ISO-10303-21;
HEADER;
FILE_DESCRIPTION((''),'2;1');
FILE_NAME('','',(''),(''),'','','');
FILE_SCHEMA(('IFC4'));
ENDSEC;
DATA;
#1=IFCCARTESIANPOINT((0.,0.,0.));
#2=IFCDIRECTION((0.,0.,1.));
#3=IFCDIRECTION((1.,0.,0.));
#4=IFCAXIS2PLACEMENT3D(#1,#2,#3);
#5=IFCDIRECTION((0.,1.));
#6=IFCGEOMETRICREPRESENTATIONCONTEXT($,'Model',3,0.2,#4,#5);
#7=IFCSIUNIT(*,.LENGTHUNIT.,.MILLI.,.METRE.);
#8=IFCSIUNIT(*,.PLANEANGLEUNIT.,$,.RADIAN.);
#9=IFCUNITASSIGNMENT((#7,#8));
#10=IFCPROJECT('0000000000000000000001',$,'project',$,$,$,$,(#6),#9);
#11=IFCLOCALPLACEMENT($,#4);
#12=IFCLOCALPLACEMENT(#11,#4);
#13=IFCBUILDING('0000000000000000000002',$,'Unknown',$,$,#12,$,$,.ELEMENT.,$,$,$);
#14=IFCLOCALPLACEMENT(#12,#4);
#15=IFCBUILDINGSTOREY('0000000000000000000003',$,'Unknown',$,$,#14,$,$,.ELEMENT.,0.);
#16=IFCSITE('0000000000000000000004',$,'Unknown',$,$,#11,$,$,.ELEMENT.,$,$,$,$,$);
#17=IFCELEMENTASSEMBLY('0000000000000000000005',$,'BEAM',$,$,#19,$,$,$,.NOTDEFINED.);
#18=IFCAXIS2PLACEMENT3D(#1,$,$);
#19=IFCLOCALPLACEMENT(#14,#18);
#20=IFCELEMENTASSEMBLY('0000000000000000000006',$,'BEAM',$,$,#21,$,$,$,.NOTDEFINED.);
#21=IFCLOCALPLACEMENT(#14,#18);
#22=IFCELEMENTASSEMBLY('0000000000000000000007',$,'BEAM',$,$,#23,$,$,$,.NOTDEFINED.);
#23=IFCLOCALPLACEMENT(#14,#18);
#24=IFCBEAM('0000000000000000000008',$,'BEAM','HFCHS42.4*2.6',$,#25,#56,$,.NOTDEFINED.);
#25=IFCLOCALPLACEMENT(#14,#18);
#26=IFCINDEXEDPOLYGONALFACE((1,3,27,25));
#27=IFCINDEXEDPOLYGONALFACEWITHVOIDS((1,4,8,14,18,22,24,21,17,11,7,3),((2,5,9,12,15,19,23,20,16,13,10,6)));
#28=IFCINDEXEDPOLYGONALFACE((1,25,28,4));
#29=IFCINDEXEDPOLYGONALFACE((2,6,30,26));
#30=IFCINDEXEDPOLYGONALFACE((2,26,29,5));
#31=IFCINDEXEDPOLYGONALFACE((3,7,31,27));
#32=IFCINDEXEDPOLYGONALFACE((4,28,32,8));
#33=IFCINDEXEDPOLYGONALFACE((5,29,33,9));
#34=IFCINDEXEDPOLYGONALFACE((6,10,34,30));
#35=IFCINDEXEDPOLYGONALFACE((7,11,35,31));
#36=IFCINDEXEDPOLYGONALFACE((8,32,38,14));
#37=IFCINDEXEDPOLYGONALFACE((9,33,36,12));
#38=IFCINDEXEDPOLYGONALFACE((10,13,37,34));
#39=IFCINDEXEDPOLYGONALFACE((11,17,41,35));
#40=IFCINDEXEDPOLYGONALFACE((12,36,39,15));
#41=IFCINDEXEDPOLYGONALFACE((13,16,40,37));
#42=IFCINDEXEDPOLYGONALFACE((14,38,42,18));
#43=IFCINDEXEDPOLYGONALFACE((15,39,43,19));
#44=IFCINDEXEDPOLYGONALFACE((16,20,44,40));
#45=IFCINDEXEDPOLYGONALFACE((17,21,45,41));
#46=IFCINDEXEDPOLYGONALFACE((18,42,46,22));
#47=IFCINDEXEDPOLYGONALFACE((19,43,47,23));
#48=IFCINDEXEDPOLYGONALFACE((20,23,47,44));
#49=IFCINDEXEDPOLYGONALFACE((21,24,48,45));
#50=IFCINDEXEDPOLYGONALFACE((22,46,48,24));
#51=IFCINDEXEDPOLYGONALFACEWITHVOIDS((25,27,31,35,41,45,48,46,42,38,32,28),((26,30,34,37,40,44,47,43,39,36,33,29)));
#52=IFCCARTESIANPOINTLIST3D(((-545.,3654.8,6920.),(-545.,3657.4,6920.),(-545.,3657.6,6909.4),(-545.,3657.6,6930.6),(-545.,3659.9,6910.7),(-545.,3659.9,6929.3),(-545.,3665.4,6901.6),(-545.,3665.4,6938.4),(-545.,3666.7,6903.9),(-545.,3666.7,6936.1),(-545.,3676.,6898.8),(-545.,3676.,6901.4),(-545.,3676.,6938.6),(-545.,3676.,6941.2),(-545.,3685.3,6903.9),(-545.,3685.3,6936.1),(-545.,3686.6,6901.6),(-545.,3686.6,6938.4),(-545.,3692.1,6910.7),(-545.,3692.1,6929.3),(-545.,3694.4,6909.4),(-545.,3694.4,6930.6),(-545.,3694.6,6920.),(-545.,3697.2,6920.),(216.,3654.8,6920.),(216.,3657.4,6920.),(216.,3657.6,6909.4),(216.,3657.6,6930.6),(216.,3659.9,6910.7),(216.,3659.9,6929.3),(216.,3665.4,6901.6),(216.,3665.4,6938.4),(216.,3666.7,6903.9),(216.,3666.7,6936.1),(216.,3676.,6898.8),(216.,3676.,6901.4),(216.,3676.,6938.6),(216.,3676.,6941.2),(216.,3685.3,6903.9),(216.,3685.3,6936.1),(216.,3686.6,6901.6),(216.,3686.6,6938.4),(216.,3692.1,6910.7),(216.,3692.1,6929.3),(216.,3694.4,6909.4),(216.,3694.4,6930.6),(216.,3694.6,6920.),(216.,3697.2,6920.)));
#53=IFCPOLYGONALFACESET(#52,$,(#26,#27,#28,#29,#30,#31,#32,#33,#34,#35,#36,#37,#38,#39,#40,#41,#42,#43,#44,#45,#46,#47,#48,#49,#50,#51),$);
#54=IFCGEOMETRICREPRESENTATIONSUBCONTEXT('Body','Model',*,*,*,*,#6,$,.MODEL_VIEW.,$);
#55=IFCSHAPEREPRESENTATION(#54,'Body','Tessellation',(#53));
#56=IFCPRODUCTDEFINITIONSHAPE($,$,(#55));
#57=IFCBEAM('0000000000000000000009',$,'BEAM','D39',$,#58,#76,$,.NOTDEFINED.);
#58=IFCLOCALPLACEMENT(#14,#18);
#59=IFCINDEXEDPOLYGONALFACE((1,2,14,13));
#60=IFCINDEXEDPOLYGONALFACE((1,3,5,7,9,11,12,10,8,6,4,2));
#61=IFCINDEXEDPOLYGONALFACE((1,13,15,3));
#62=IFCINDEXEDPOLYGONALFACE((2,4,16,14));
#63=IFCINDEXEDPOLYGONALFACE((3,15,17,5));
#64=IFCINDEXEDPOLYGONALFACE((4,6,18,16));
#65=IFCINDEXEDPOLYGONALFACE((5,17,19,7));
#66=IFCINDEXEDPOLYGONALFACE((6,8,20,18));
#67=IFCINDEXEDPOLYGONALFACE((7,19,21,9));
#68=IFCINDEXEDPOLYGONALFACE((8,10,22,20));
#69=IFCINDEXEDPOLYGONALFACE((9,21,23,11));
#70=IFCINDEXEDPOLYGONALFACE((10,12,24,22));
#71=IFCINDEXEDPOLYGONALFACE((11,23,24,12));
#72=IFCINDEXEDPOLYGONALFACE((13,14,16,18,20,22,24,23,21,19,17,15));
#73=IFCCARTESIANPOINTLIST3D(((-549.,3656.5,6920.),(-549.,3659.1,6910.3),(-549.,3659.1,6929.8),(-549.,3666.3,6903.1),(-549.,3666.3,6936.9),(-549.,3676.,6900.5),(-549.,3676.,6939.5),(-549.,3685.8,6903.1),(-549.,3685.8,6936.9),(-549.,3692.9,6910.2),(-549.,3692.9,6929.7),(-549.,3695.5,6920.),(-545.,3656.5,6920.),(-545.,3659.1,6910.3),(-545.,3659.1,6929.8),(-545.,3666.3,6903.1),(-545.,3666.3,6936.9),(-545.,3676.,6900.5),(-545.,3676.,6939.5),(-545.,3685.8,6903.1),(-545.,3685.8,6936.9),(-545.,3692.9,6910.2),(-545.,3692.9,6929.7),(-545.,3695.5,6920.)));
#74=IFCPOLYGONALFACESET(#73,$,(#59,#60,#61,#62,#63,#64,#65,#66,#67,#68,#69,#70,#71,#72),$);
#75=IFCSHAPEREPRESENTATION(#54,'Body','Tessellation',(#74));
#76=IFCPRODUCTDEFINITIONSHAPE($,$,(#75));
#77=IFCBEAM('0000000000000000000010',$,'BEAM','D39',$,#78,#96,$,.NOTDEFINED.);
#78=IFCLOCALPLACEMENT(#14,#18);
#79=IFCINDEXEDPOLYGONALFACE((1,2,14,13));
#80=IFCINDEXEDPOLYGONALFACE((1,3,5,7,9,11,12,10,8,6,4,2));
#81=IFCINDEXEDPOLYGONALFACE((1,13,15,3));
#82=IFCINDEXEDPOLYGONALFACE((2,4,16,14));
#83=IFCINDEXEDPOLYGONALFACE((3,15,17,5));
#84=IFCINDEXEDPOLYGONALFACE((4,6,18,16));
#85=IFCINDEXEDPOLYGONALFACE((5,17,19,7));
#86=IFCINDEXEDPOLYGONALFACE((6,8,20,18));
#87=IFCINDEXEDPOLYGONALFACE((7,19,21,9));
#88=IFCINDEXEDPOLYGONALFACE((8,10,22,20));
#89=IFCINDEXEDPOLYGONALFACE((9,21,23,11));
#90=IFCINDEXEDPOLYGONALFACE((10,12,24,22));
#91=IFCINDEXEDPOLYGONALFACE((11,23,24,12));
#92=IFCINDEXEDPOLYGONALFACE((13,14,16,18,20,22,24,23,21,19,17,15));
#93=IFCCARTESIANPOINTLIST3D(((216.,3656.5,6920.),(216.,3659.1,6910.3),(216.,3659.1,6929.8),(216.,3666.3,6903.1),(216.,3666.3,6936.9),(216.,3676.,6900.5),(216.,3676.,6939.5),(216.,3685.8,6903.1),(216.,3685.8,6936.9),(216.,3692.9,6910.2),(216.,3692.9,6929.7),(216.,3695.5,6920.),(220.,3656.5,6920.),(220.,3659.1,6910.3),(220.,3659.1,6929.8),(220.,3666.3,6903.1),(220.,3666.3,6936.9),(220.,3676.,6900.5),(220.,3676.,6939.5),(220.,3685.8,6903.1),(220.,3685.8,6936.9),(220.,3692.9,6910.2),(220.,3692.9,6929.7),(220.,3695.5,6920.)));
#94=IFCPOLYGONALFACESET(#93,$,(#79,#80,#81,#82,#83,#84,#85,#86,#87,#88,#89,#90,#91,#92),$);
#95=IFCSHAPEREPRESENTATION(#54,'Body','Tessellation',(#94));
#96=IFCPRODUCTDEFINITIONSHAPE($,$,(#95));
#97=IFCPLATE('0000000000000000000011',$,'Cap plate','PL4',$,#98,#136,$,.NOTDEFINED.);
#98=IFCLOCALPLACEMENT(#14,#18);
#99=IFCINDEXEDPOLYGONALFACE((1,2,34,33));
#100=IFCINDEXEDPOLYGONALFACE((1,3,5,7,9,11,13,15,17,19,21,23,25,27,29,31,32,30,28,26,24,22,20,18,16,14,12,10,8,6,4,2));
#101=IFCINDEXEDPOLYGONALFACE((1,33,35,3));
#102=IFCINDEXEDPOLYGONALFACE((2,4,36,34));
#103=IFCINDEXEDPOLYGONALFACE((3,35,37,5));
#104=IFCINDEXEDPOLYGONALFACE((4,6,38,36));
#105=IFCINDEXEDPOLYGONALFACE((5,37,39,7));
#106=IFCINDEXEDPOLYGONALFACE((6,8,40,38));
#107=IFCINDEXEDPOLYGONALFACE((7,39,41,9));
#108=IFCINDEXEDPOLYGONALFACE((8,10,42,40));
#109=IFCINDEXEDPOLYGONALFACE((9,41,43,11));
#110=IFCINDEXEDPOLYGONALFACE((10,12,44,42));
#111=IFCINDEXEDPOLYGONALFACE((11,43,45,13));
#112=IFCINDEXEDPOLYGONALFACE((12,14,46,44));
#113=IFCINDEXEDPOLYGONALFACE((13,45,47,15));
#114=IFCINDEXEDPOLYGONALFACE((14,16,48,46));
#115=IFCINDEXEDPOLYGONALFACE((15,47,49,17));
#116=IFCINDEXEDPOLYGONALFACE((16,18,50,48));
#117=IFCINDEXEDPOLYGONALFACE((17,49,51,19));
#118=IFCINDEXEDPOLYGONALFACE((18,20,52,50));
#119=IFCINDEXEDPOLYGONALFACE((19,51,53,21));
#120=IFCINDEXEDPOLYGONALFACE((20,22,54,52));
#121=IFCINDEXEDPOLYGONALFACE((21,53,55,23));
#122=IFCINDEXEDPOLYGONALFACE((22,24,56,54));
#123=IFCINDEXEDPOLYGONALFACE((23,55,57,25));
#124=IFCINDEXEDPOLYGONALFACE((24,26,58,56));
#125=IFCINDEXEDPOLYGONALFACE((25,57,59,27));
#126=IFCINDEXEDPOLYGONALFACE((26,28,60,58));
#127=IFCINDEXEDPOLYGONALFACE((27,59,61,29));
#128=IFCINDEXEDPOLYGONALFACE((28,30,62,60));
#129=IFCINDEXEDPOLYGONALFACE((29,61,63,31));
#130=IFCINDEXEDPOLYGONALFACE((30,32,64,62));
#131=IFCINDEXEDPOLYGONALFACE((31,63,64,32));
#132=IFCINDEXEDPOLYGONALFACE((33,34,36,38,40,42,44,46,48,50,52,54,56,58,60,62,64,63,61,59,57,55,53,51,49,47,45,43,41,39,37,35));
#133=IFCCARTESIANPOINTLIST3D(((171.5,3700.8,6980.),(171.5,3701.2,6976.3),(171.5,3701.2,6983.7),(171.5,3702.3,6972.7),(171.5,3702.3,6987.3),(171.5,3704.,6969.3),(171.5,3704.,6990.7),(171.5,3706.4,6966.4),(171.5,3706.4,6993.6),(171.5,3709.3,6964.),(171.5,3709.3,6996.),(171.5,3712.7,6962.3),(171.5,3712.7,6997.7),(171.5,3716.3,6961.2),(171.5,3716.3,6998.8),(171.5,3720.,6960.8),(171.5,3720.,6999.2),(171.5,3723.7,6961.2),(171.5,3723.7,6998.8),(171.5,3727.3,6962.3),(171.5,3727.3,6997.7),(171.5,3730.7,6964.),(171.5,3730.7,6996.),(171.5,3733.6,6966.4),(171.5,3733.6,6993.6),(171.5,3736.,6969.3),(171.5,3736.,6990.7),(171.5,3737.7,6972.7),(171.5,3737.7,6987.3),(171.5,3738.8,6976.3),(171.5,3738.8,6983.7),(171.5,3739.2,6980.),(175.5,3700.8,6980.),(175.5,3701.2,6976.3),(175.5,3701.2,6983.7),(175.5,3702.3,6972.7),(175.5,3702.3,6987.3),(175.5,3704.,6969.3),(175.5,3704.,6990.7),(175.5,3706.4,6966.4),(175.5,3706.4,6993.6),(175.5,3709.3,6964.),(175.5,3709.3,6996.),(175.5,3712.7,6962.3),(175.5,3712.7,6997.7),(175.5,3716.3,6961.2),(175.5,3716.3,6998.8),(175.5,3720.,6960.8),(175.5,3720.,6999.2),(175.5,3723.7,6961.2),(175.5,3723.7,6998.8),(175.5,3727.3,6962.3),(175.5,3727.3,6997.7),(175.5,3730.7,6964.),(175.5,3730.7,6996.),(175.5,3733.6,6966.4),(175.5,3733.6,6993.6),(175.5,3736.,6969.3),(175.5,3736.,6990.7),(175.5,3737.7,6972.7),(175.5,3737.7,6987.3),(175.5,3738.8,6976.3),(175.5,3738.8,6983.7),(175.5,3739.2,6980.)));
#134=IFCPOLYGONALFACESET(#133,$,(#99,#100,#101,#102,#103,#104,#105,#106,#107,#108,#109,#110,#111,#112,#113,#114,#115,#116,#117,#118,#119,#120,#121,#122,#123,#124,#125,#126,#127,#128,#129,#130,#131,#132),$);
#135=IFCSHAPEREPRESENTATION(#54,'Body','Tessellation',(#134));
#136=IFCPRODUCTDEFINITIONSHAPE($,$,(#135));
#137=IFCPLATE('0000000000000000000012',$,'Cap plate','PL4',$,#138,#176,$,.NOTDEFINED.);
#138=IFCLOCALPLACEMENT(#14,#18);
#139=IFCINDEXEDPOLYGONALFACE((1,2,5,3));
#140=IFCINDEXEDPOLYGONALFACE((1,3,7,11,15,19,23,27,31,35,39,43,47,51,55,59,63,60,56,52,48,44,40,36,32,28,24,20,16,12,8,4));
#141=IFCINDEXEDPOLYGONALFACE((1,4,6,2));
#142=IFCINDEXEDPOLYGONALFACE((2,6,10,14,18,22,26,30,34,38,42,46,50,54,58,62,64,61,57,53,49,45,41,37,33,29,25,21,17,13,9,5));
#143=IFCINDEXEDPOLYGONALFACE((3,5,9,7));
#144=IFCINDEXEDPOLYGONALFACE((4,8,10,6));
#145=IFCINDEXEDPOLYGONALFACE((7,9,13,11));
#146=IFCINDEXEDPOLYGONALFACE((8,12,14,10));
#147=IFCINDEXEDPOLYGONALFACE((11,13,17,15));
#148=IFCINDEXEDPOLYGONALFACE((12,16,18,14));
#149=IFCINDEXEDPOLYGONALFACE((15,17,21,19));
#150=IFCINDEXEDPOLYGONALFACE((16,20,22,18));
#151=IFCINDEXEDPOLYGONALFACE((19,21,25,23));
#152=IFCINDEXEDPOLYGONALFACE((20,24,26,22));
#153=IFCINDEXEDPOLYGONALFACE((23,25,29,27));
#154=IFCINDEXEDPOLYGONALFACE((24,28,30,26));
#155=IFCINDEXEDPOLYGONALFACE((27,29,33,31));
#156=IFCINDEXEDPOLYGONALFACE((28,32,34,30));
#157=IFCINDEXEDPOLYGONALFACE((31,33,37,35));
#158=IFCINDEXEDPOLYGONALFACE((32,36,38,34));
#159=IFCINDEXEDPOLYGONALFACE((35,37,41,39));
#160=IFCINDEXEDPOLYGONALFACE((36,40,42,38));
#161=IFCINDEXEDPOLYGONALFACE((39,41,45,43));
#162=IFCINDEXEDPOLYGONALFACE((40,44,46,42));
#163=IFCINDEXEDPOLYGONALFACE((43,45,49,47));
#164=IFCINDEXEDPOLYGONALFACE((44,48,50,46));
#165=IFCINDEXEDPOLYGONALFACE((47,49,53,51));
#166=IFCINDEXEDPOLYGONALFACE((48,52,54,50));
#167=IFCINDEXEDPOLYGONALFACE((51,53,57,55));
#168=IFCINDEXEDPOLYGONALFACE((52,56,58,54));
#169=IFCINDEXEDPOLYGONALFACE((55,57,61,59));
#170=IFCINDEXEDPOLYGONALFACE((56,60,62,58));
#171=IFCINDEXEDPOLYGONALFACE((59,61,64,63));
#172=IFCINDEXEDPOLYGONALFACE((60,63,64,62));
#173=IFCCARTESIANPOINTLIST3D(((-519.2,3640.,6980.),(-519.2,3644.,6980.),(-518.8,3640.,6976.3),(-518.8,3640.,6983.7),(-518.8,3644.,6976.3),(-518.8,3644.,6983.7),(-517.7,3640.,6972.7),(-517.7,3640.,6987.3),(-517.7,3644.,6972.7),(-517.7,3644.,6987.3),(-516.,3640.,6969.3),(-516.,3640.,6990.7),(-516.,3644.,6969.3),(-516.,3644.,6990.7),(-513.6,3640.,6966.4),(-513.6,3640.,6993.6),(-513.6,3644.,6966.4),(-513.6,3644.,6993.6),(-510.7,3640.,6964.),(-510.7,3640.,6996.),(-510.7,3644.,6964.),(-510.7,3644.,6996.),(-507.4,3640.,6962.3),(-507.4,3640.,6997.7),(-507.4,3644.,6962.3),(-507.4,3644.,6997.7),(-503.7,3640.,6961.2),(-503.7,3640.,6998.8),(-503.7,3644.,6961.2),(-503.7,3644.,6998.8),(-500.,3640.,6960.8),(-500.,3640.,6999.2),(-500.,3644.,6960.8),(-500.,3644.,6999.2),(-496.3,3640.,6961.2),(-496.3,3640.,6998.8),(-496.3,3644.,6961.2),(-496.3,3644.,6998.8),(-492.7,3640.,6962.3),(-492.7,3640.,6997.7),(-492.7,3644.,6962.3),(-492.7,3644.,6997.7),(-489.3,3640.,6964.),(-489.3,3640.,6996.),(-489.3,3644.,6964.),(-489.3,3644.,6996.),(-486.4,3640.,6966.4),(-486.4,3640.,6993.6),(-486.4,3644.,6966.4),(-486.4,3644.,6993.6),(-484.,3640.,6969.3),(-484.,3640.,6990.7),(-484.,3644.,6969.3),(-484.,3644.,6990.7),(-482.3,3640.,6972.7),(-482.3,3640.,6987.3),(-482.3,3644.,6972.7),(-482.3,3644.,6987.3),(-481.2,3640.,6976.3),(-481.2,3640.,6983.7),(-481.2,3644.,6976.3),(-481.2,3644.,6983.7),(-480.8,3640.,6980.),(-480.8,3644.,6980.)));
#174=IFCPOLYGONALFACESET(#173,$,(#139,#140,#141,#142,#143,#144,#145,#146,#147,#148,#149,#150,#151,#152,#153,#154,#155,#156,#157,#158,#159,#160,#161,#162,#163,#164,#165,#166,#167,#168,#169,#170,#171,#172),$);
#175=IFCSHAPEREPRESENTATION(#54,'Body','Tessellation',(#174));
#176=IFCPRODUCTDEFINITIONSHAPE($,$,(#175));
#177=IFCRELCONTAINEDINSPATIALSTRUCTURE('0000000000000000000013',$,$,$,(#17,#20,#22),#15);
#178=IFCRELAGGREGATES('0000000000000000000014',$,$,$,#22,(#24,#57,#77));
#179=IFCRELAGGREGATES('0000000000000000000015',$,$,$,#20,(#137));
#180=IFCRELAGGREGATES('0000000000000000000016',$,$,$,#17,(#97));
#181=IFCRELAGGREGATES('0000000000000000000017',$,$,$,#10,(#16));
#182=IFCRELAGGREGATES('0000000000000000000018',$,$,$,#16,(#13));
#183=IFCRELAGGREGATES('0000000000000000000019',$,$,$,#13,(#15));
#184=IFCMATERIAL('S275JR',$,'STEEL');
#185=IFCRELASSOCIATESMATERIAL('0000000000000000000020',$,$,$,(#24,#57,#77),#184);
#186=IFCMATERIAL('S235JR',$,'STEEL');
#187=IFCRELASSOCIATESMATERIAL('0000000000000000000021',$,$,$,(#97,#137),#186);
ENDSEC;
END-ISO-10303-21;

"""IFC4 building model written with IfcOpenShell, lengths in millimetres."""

from ifc_helpers import new_model, si_unit, direction, frame, origin_with_axes, place, context, subcontext, project, spatial, line, indexed_curve, outline, extrude, material, element, aggregate, save


model = new_model("IFC4")

# Units and contexts
model_context = context("Model", 3, precision=0.2, world=origin_with_axes(), true_north=direction((0.0, 1.0)))
body_context = subcontext(model_context, "Body", "Model", "MODEL_VIEW")
ifc_project = project(units=[si_unit("LENGTHUNIT", "METRE", prefix="MILLI"), si_unit("PLANEANGLEUNIT", "RADIAN")], contexts=[model_context])

# Site, building, storey
site_placement = place(None, origin_with_axes())
site = spatial("IfcSite", under=ifc_project, at=site_placement, Name="Unknown", CompositionType="ELEMENT")
building_placement = place(site_placement, origin_with_axes())
building = spatial("IfcBuilding", under=site, at=building_placement, Name="Unknown", CompositionType="ELEMENT")
storey_placement = place(building_placement, origin_with_axes())
storey = spatial("IfcBuildingStorey", under=building, at=storey_placement, Name="Unknown", CompositionType="ELEMENT", Elevation=0.0)

# Element assemblies
assembly_1_placement = place(storey_placement, frame((175.5, 3720.0, 6980.0), z_axis=(0.0, -1.0, 0.000002), x_axis=(1.0, 0.0, 0.0)))
assembly_1 = element("IfcElementAssembly", 1, at=assembly_1_placement, inside=storey, Name="BEAM", PredefinedType="NOTDEFINED")
ifc_material_1 = material(Name="S275JR", Category="STEEL")
assembly_2_placement = place(storey_placement, frame((-500.0, 3640.0, 6980.0), z_axis=(-1.0, -0.00002, 0.0), x_axis=(0.000011, -1.0, 0.0)))
assembly_2 = element("IfcElementAssembly", 2, at=assembly_2_placement, inside=storey, Name="BEAM", PredefinedType="NOTDEFINED")

# Element assembly, beams
assembly_3_placement = place(storey_placement, frame((-545.0, 3676.0, 6920.0), z_axis=(0.0, -1.0, 0.000002), x_axis=(1.0, 0.0, 0.0)))
assembly_3 = element("IfcElementAssembly", 3, at=assembly_3_placement, inside=storey, Name="BEAM", PredefinedType="NOTDEFINED")
beam_1_placement = place(assembly_3_placement, origin_with_axes())
beam_1 = element("IfcBeam", 4, at=beam_1_placement, material=ifc_material_1, Name="BEAM", Description="HFCHS42.4*2.6", PredefinedType="NOTDEFINED", context=body_context, shape_type="SolidModel", body=[
    extrude(outline(indexed_curve([(21.2, 0.0), (18.4, 10.6), (10.6, 18.4), (0.0, 21.2), (-10.6, 18.4), (-18.4, 10.6), (-21.2, 0.0), (-18.4, -10.6), (-10.6, -18.4), (0.0, -21.2), (10.6, -18.4), (18.4, -10.6)], segments=[line(1, 2, 3, 4, 5, 6, 7, 8, 9, 10, 11, 12, 1)]), holes=[indexed_curve([(18.6, 0.0), (16.1, -9.3), (9.3, -16.1), (0.0, -18.6), (-9.3, -16.1), (-16.1, -9.3), (-18.6, 0.0), (-16.1, 9.3), (-9.3, 16.1), (0.0, 18.6), (9.3, 16.1), (16.1, 9.3)], segments=[line(1, 2, 3, 4, 5, 6, 7, 8, 9, 10, 11, 12, 1)])]), frame((0.0, 0.0, 0.0), z_axis=(-1.0, 0.0, 0.0), x_axis=(0.0, 0.0, 1.0)), (0.0, -0.000002, -1.0), 761.0),
])
beam_2_placement = place(assembly_3_placement, frame((0.0, 0.0, 0.0), z_axis=(0.0, -0.000002, -1.0), x_axis=(-1.0, 0.0, 0.0)))
beam_2 = element("IfcBeam", 5, at=beam_2_placement, material=ifc_material_1, Name="BEAM", Description="D39", PredefinedType="NOTDEFINED", context=body_context, shape_type="SolidModel", body=[
    extrude(outline(indexed_curve([(19.5, 0.0), (16.9, 9.8), (9.8, 16.9), (0.0, 19.5), (-9.8, 16.9), (-16.9, 9.8), (-19.5, 0.0), (-16.9, -9.8), (-9.8, -16.9), (0.0, -19.5), (9.8, -16.9), (16.9, -9.8)], segments=[line(1, 2, 3, 4, 5, 6, 7, 8, 9, 10, 11, 12, 1)])), frame((0.0, 0.0, 0.0), z_axis=(-1.0, 0.0, 0.0), x_axis=(0.0, 0.0, 1.0)), (0.0, -0.000002, -1.0), 4.0),
])
beam_3_placement = place(assembly_3_placement, frame((761.0, 0.0, 0.0), z_axis=(0.0, 0.0, 1.0), x_axis=(1.0, 0.0, 0.0)))
beam_3 = element("IfcBeam", 6, at=beam_3_placement, material=ifc_material_1, Name="BEAM", Description="D39", PredefinedType="NOTDEFINED", context=body_context, shape_type="SolidModel", body=[
    extrude(outline(indexed_curve([(19.5, 0.0), (16.9, 9.8), (9.8, 16.9), (0.0, 19.5), (-9.8, 16.9), (-16.9, 9.8), (-19.5, 0.0), (-16.9, -9.8), (-9.8, -16.9), (0.0, -19.5), (9.8, -16.9), (16.9, -9.8)], segments=[line(1, 2, 3, 4, 5, 6, 7, 8, 9, 10, 11, 12, 1)])), frame((0.0, 0.0, 0.0), z_axis=(-1.0, 0.0, 0.0), x_axis=(0.0, 0.0, 1.0)), (0.0, -0.000002, -1.0), 4.0),
])
aggregate(assembly_3, [beam_1, beam_2, beam_3])

# Plates
ifc_material_2 = material(Name="S235JR", Category="STEEL")
plate_1_placement = place(assembly_1_placement, frame((-2.0, 18.8, -3.7), z_axis=(-1.0, 0.0, 0.0), x_axis=(0.0, -0.290285, -0.95694)))
plate_1 = element("IfcPlate", 7, at=plate_1_placement, material=ifc_material_2, Name="Cap plate", Description="PL4", PredefinedType="NOTDEFINED", context=body_context, shape_type="SolidModel", body=[
    extrude(outline(indexed_curve([(0.0, 0.0), (3.8, 0.0), (7.5, 0.7), (10.9, 2.2), (14.1, 4.3), (16.7, 6.9), (18.8, 10.1), (20.3, 13.5), (21.0, 17.2), (21.0, 21.0), (20.3, 24.7), (18.8, 28.2), (16.7, 31.3), (14.1, 33.9), (10.9, 36.0), (7.5, 37.5), (3.8, 38.2), (0.0, 38.2), (-3.7, 37.5), (-7.2, 36.0), (-10.3, 33.9), (-13.0, 31.3), (-15.1, 28.2), (-16.5, 24.7), (-17.2, 21.0), (-17.2, 17.2), (-16.5, 13.5), (-15.1, 10.1), (-13.0, 6.9), (-10.3, 4.3), (-7.2, 2.2), (-3.7, 0.7)], segments=[line(1, 2, 3, 4, 5, 6, 7, 8, 9, 10, 11, 12, 13, 14, 15, 16, 17, 18, 19, 20, 21, 22, 23, 24, 25, 26, 27, 28, 29, 30, 31, 32, 1)])), frame((0.0, 0.0, 2.0), z_axis=(0.0, 0.0, 1.0), x_axis=(1.0, 0.0, 0.0)), (0.0, -0.000002, -1.0), 4.0),
])
plate_2_placement = place(assembly_2_placement, frame((-2.0, 18.8, -3.7), z_axis=(-1.0, 0.0, 0.0), x_axis=(0.0, -0.290285, -0.95694)))
plate_2 = element("IfcPlate", 8, at=plate_2_placement, material=ifc_material_2, Name="Cap plate", Description="PL4", PredefinedType="NOTDEFINED", context=body_context, shape_type="SolidModel", body=[
    extrude(outline(indexed_curve([(0.0, 0.0), (3.8, 0.0), (7.5, 0.7), (10.9, 2.2), (14.1, 4.3), (16.7, 6.9), (18.8, 10.1), (20.3, 13.5), (21.0, 17.2), (21.0, 21.0), (20.3, 24.7), (18.8, 28.2), (16.7, 31.3), (14.1, 33.9), (10.9, 36.0), (7.5, 37.5), (3.8, 38.2), (0.0, 38.2), (-3.7, 37.5), (-7.2, 36.0), (-10.3, 33.9), (-13.0, 31.3), (-15.1, 28.2), (-16.5, 24.7), (-17.2, 21.0), (-17.2, 17.2), (-16.5, 13.5), (-15.1, 10.1), (-13.0, 6.9), (-10.3, 4.3), (-7.2, 2.2), (-3.7, 0.7)], segments=[line(1, 2, 3, 4, 5, 6, 7, 8, 9, 10, 11, 12, 13, 14, 15, 16, 17, 18, 19, 20, 21, 22, 23, 24, 25, 26, 27, 28, 29, 30, 31, 32, 1)])), frame((0.0, 0.0, 2.0), z_axis=(0.0, 0.0, 1.0), x_axis=(1.0, 0.0, 0.0)), (0.0, -0.000002, -1.0), 4.0),
])

aggregate(assembly_2, [plate_2])
aggregate(assembly_1, [plate_1])

save(model, "model.ifc")
